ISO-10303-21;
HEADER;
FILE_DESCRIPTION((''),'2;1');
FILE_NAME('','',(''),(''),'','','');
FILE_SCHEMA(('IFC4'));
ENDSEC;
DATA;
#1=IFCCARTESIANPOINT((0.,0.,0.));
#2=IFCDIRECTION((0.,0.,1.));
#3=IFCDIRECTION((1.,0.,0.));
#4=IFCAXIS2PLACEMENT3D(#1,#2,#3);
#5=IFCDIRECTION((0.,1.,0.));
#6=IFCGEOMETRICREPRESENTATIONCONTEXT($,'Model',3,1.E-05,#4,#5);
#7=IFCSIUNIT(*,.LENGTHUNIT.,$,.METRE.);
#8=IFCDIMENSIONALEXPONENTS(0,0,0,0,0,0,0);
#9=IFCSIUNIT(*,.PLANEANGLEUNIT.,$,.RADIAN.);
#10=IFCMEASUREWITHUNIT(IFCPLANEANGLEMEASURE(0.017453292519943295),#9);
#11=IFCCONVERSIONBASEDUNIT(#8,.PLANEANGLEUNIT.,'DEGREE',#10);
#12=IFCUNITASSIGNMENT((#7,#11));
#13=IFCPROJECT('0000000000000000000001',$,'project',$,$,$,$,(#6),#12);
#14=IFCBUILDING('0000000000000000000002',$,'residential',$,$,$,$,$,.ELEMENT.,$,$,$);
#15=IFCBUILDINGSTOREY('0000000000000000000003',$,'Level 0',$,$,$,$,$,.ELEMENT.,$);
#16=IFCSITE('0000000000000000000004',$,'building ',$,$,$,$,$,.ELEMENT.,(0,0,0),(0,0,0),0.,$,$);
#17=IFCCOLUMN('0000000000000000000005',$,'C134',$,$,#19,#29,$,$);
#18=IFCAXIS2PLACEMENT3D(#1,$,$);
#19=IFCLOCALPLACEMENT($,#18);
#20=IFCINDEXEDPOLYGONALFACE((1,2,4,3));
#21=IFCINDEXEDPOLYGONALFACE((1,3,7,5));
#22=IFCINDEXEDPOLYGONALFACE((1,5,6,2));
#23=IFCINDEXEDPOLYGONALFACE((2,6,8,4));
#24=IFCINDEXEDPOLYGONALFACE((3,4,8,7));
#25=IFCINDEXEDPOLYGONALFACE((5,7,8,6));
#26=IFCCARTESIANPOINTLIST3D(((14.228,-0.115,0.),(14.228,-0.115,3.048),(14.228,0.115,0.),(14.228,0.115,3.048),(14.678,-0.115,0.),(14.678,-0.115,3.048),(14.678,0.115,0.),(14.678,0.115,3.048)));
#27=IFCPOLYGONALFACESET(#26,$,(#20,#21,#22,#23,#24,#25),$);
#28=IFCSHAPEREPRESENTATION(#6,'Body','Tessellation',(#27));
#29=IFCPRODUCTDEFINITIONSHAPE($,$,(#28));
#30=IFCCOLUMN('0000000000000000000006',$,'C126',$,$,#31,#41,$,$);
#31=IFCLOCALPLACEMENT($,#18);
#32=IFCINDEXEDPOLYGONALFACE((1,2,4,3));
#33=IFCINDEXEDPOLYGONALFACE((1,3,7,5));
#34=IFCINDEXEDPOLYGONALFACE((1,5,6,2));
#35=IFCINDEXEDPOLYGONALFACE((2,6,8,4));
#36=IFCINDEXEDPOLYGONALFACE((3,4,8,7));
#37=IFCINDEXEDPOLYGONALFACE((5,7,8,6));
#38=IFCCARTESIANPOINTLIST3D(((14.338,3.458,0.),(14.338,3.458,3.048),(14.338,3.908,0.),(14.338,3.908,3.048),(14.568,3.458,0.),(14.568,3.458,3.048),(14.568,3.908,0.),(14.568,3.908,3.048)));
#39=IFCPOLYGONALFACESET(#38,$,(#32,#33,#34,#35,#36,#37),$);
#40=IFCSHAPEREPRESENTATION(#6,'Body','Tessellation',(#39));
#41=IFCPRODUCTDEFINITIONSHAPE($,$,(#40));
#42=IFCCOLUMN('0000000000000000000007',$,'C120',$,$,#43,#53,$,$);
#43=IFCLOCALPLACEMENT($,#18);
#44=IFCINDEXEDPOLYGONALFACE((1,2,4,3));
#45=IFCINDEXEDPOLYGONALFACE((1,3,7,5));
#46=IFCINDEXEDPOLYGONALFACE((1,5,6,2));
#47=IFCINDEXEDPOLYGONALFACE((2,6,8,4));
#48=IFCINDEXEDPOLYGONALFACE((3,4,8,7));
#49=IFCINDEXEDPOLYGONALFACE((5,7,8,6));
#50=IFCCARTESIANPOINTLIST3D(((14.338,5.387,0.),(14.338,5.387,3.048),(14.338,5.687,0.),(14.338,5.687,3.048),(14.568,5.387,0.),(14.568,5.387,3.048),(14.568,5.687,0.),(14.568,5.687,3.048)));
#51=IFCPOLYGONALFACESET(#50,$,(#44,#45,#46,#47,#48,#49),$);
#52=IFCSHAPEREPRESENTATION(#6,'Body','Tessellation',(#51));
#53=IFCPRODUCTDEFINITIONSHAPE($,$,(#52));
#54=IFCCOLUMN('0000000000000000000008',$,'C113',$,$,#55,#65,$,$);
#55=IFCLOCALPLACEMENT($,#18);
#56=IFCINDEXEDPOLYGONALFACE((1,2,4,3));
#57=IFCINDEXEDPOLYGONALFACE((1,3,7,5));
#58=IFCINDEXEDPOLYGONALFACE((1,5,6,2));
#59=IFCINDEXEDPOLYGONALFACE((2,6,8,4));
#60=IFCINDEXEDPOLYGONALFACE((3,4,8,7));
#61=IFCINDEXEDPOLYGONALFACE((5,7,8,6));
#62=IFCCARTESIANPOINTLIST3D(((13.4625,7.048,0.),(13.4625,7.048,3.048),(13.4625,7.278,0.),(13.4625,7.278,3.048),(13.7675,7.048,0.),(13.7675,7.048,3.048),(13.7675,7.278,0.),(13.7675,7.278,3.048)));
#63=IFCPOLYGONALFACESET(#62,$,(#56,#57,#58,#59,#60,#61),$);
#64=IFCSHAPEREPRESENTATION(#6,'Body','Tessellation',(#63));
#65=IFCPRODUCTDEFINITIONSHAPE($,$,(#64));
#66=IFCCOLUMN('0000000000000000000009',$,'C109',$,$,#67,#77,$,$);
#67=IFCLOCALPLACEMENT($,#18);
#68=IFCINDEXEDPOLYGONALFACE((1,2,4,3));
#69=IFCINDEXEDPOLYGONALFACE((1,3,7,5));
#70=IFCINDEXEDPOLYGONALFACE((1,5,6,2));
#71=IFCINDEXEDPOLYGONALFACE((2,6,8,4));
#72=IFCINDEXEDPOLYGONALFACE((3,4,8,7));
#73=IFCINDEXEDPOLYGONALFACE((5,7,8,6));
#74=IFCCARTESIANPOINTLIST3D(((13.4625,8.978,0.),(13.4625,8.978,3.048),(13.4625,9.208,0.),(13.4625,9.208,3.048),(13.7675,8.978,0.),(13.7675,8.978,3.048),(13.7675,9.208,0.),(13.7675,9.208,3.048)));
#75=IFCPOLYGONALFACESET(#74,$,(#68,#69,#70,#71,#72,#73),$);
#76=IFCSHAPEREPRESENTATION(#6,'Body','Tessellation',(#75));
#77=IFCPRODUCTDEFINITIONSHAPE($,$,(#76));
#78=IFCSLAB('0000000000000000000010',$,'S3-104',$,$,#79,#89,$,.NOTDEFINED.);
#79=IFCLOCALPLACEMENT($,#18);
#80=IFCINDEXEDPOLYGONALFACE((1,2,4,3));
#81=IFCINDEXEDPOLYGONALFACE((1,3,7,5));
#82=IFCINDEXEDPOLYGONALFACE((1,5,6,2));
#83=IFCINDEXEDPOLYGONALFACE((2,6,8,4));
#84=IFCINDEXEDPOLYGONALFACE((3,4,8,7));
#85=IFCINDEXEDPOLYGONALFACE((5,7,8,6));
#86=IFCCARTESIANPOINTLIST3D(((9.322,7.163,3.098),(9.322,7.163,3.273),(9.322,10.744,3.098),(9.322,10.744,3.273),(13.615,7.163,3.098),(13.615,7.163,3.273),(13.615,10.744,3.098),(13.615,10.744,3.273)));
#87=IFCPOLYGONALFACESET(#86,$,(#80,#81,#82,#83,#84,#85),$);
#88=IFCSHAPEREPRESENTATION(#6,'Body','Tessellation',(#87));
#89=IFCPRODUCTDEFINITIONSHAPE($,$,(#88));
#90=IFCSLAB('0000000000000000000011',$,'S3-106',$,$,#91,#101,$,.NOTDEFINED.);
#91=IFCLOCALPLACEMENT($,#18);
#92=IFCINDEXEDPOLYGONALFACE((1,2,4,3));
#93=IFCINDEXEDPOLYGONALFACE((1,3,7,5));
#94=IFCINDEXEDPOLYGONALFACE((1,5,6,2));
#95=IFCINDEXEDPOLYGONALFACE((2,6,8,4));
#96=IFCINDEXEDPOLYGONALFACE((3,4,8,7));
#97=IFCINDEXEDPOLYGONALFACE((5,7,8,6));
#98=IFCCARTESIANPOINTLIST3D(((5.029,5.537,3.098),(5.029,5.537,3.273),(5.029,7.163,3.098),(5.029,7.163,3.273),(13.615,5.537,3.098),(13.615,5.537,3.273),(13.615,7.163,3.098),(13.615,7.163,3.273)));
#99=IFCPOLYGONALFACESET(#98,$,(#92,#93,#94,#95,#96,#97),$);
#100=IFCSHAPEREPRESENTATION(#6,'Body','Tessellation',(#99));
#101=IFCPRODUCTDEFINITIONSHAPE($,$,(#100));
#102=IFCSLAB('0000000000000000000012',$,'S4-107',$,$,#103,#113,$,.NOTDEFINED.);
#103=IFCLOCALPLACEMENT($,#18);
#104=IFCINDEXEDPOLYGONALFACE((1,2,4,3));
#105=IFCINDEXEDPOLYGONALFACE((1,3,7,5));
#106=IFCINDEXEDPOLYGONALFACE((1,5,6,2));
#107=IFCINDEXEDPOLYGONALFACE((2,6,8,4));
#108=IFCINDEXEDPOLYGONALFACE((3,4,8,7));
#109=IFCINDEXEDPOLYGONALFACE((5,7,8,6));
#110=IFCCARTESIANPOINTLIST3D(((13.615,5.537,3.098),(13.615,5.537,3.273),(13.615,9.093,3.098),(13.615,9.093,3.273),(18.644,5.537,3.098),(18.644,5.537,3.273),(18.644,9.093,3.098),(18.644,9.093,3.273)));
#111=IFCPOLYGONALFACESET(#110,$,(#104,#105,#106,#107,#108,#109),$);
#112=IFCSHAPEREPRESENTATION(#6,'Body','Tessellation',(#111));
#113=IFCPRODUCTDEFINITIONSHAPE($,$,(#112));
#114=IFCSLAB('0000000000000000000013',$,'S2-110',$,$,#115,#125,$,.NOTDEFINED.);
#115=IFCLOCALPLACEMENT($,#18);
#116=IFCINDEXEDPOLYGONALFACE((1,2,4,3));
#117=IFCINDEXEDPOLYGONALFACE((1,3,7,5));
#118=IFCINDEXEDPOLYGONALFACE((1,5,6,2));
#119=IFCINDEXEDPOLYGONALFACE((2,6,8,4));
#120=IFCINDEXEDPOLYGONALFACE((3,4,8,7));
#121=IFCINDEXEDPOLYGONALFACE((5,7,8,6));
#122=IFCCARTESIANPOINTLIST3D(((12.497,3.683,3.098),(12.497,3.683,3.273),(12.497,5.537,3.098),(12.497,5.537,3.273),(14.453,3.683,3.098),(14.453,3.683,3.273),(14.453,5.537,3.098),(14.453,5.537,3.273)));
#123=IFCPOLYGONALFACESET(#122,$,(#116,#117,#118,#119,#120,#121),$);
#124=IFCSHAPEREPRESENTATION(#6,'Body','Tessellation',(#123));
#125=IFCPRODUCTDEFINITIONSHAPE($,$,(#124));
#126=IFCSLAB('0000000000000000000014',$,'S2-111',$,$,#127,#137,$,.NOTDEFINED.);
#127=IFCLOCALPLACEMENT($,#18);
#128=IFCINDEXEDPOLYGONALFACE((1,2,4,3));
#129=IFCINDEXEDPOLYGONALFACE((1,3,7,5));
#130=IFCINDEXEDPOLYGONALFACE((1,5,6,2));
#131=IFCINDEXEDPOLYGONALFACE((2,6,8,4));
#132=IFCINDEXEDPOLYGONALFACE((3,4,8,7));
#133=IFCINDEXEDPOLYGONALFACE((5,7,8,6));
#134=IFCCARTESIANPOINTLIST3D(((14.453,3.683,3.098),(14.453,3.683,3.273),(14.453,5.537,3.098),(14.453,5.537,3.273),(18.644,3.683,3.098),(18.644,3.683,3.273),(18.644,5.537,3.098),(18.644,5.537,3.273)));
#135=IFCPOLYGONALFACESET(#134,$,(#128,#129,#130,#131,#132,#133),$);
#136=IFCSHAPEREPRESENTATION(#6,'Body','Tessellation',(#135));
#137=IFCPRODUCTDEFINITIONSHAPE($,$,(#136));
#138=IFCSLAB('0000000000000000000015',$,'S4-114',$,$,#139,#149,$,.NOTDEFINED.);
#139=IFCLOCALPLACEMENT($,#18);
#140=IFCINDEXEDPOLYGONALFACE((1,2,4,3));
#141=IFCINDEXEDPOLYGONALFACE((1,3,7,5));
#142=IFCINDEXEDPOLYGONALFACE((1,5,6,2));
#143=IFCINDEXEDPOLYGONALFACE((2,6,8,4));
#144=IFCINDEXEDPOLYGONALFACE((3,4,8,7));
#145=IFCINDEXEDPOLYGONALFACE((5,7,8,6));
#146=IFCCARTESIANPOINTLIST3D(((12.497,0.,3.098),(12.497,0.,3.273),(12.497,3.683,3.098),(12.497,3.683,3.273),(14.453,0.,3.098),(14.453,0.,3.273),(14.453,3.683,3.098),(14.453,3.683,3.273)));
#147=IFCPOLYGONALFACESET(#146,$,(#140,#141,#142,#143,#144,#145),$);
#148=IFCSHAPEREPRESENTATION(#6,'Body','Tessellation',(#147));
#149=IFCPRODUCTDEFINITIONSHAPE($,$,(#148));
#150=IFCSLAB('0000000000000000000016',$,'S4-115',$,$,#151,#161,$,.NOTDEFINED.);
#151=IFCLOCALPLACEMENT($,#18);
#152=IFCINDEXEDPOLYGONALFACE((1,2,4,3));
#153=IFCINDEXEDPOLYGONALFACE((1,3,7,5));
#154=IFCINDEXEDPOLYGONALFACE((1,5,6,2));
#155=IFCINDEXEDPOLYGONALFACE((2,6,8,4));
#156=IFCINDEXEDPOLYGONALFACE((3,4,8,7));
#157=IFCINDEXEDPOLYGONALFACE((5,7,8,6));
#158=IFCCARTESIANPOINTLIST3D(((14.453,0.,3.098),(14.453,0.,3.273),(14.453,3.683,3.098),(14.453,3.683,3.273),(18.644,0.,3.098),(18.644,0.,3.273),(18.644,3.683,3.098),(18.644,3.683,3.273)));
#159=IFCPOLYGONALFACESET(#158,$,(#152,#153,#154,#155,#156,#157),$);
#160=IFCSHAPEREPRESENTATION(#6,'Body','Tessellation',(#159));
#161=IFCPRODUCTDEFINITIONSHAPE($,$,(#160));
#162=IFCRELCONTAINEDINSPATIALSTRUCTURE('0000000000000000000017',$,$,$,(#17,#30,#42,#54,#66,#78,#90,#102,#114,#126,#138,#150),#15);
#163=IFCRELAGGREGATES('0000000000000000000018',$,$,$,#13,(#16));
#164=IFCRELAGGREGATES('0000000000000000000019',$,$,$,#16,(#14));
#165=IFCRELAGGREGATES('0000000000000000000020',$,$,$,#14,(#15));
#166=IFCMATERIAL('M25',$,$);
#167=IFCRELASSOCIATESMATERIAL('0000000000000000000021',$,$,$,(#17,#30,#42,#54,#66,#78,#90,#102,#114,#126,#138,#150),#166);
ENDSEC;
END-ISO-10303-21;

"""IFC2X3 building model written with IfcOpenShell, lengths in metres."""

from ifc_helpers import new_model, entity, si_unit, converted_unit, direction, frame, frame_2d, origin_with_axes, place, context, project, spatial, rectangle, extrude, material, element, save


model = new_model("IFC2X3")

# Units and contexts
model_context = context("Model", 3, precision=1e-05, world=origin_with_axes(), true_north=direction((0.0, 1.0, 0.0)))
ifc_project = project(units=[si_unit("LENGTHUNIT", "METRE"), converted_unit("PLANEANGLEUNIT", "DEGREE", entity("IfcPlaneAngleMeasure", 0.017453292519943295), si_unit("PLANEANGLEUNIT", "RADIAN"), dimensions=[0, 0, 0, 0, 0, 0, 0])], contexts=[model_context])

# Site, building, storey
site = spatial("IfcSite", under=ifc_project, Name="building ", CompositionType="ELEMENT", RefLatitude=(0, 0, 0), RefLongitude=(0, 0, 0), RefElevation=0.0)
building = spatial("IfcBuilding", under=site, Name="residential", CompositionType="ELEMENT")
storey = spatial("IfcBuildingStorey", under=building, Name="Level 0", CompositionType="ELEMENT")

# Columns
ifc_material = material(Name="M25")
placement = place(None, origin_with_axes())
element("IfcColumn", 1, at=placement, inside=storey, material=ifc_material, Name="C134", context=model_context, shape_type="SweptSolid", body=[
    extrude(rectangle(XDim=0.45, YDim=0.23, at=frame_2d((0.0, 0.0), x_axis=(1.0, 0.0, 0.0))), frame((14.453, 0.0, 0.0), z_axis=(0.0, 0.0, 1.0), x_axis=(1.0, 0.0, 0.0)), (0.0, 0.0, 1.0), 3.048),
])
element("IfcColumn", 2, at=placement, inside=storey, material=ifc_material, Name="C126", context=model_context, shape_type="SweptSolid", body=[
    extrude(rectangle(XDim=0.23, YDim=0.45, at=frame_2d((0.0, 0.0), x_axis=(1.0, 0.0, 0.0))), frame((14.453, 3.683, 0.0), z_axis=(0.0, 0.0, 1.0), x_axis=(1.0, 0.0, 0.0)), (0.0, 0.0, 1.0), 3.048),
])
element("IfcColumn", 3, at=placement, inside=storey, material=ifc_material, Name="C120", context=model_context, shape_type="SweptSolid", body=[
    extrude(rectangle(XDim=0.23, YDim=0.3, at=frame_2d((0.0, 0.0), x_axis=(1.0, 0.0, 0.0))), frame((14.453, 5.537, 0.0), z_axis=(0.0, 0.0, 1.0), x_axis=(1.0, 0.0, 0.0)), (0.0, 0.0, 1.0), 3.048),
])
element("IfcColumn", 4, at=placement, inside=storey, material=ifc_material, Name="C113", context=model_context, shape_type="SweptSolid", body=[
    extrude(rectangle(XDim=0.305, YDim=0.23, at=frame_2d((0.0, 0.0), x_axis=(1.0, 0.0, 0.0))), frame((13.615, 7.163, 0.0), z_axis=(0.0, 0.0, 1.0), x_axis=(1.0, 0.0, 0.0)), (0.0, 0.0, 1.0), 3.048),
])
element("IfcColumn", 5, at=placement, inside=storey, material=ifc_material, Name="C109", context=model_context, shape_type="SweptSolid", body=[
    extrude(rectangle(XDim=0.305, YDim=0.23, at=frame_2d((0.0, 0.0), x_axis=(1.0, 0.0, 0.0))), frame((13.615, 9.093, 0.0), z_axis=(0.0, 0.0, 1.0), x_axis=(1.0, 0.0, 0.0)), (0.0, 0.0, 1.0), 3.048),
])

# Slabs
element("IfcSlab", 6, at=placement, inside=storey, material=ifc_material, Name="S3-104", PredefinedType="NOTDEFINED", context=model_context, shape_type="SweptSolid", body=[
    extrude(rectangle(XDim=4.293, YDim=3.581, at=frame_2d((0.0, 0.0), x_axis=(1.0, 0.0, 0.0))), frame((11.4685, 8.9535, 3.098), z_axis=(0.0, 0.0, 1.0), x_axis=(1.0, 0.0, 0.0)), (0.0, 0.0, 1.0), 0.175),
])
element("IfcSlab", 7, at=placement, inside=storey, material=ifc_material, Name="S3-106", PredefinedType="NOTDEFINED", context=model_context, shape_type="SweptSolid", body=[
    extrude(rectangle(XDim=8.586, YDim=1.626, at=frame_2d((0.0, 0.0), x_axis=(1.0, 0.0, 0.0))), frame((9.322, 6.35, 3.098), z_axis=(0.0, 0.0, 1.0), x_axis=(1.0, 0.0, 0.0)), (0.0, 0.0, 1.0), 0.175),
])
element("IfcSlab", 8, at=placement, inside=storey, material=ifc_material, Name="S4-107", PredefinedType="NOTDEFINED", context=model_context, shape_type="SweptSolid", body=[
    extrude(rectangle(XDim=5.029, YDim=3.556, at=frame_2d((0.0, 0.0), x_axis=(1.0, 0.0, 0.0))), frame((16.1295, 7.315, 3.098), z_axis=(0.0, 0.0, 1.0), x_axis=(1.0, 0.0, 0.0)), (0.0, 0.0, 1.0), 0.175),
])
element("IfcSlab", 9, at=placement, inside=storey, material=ifc_material, Name="S2-110", PredefinedType="NOTDEFINED", context=model_context, shape_type="SweptSolid", body=[
    extrude(rectangle(XDim=1.956, YDim=1.854, at=frame_2d((0.0, 0.0), x_axis=(1.0, 0.0, 0.0))), frame((13.475, 4.61, 3.098), z_axis=(0.0, 0.0, 1.0), x_axis=(1.0, 0.0, 0.0)), (0.0, 0.0, 1.0), 0.175),
])
element("IfcSlab", 10, at=placement, inside=storey, material=ifc_material, Name="S2-111", PredefinedType="NOTDEFINED", context=model_context, shape_type="SweptSolid", body=[
    extrude(rectangle(XDim=4.191, YDim=1.854, at=frame_2d((0.0, 0.0), x_axis=(1.0, 0.0, 0.0))), frame((16.5485, 4.61, 3.098), z_axis=(0.0, 0.0, 1.0), x_axis=(1.0, 0.0, 0.0)), (0.0, 0.0, 1.0), 0.175),
])
element("IfcSlab", 11, at=placement, inside=storey, material=ifc_material, Name="S4-114", PredefinedType="NOTDEFINED", context=model_context, shape_type="SweptSolid", body=[
    extrude(rectangle(XDim=1.956, YDim=3.683, at=frame_2d((0.0, 0.0), x_axis=(1.0, 0.0, 0.0))), frame((13.475, 1.8415, 3.098), z_axis=(0.0, 0.0, 1.0), x_axis=(1.0, 0.0, 0.0)), (0.0, 0.0, 1.0), 0.175),
])
element("IfcSlab", 12, at=placement, inside=storey, material=ifc_material, Name="S4-115", PredefinedType="NOTDEFINED", context=model_context, shape_type="SweptSolid", body=[
    extrude(rectangle(XDim=4.191, YDim=3.683, at=frame_2d((0.0, 0.0), x_axis=(1.0, 0.0, 0.0))), frame((16.5485, 1.8415, 3.098), z_axis=(0.0, 0.0, 1.0), x_axis=(1.0, 0.0, 0.0)), (0.0, 0.0, 1.0), 0.175),
])

save(model, "model.ifc")
